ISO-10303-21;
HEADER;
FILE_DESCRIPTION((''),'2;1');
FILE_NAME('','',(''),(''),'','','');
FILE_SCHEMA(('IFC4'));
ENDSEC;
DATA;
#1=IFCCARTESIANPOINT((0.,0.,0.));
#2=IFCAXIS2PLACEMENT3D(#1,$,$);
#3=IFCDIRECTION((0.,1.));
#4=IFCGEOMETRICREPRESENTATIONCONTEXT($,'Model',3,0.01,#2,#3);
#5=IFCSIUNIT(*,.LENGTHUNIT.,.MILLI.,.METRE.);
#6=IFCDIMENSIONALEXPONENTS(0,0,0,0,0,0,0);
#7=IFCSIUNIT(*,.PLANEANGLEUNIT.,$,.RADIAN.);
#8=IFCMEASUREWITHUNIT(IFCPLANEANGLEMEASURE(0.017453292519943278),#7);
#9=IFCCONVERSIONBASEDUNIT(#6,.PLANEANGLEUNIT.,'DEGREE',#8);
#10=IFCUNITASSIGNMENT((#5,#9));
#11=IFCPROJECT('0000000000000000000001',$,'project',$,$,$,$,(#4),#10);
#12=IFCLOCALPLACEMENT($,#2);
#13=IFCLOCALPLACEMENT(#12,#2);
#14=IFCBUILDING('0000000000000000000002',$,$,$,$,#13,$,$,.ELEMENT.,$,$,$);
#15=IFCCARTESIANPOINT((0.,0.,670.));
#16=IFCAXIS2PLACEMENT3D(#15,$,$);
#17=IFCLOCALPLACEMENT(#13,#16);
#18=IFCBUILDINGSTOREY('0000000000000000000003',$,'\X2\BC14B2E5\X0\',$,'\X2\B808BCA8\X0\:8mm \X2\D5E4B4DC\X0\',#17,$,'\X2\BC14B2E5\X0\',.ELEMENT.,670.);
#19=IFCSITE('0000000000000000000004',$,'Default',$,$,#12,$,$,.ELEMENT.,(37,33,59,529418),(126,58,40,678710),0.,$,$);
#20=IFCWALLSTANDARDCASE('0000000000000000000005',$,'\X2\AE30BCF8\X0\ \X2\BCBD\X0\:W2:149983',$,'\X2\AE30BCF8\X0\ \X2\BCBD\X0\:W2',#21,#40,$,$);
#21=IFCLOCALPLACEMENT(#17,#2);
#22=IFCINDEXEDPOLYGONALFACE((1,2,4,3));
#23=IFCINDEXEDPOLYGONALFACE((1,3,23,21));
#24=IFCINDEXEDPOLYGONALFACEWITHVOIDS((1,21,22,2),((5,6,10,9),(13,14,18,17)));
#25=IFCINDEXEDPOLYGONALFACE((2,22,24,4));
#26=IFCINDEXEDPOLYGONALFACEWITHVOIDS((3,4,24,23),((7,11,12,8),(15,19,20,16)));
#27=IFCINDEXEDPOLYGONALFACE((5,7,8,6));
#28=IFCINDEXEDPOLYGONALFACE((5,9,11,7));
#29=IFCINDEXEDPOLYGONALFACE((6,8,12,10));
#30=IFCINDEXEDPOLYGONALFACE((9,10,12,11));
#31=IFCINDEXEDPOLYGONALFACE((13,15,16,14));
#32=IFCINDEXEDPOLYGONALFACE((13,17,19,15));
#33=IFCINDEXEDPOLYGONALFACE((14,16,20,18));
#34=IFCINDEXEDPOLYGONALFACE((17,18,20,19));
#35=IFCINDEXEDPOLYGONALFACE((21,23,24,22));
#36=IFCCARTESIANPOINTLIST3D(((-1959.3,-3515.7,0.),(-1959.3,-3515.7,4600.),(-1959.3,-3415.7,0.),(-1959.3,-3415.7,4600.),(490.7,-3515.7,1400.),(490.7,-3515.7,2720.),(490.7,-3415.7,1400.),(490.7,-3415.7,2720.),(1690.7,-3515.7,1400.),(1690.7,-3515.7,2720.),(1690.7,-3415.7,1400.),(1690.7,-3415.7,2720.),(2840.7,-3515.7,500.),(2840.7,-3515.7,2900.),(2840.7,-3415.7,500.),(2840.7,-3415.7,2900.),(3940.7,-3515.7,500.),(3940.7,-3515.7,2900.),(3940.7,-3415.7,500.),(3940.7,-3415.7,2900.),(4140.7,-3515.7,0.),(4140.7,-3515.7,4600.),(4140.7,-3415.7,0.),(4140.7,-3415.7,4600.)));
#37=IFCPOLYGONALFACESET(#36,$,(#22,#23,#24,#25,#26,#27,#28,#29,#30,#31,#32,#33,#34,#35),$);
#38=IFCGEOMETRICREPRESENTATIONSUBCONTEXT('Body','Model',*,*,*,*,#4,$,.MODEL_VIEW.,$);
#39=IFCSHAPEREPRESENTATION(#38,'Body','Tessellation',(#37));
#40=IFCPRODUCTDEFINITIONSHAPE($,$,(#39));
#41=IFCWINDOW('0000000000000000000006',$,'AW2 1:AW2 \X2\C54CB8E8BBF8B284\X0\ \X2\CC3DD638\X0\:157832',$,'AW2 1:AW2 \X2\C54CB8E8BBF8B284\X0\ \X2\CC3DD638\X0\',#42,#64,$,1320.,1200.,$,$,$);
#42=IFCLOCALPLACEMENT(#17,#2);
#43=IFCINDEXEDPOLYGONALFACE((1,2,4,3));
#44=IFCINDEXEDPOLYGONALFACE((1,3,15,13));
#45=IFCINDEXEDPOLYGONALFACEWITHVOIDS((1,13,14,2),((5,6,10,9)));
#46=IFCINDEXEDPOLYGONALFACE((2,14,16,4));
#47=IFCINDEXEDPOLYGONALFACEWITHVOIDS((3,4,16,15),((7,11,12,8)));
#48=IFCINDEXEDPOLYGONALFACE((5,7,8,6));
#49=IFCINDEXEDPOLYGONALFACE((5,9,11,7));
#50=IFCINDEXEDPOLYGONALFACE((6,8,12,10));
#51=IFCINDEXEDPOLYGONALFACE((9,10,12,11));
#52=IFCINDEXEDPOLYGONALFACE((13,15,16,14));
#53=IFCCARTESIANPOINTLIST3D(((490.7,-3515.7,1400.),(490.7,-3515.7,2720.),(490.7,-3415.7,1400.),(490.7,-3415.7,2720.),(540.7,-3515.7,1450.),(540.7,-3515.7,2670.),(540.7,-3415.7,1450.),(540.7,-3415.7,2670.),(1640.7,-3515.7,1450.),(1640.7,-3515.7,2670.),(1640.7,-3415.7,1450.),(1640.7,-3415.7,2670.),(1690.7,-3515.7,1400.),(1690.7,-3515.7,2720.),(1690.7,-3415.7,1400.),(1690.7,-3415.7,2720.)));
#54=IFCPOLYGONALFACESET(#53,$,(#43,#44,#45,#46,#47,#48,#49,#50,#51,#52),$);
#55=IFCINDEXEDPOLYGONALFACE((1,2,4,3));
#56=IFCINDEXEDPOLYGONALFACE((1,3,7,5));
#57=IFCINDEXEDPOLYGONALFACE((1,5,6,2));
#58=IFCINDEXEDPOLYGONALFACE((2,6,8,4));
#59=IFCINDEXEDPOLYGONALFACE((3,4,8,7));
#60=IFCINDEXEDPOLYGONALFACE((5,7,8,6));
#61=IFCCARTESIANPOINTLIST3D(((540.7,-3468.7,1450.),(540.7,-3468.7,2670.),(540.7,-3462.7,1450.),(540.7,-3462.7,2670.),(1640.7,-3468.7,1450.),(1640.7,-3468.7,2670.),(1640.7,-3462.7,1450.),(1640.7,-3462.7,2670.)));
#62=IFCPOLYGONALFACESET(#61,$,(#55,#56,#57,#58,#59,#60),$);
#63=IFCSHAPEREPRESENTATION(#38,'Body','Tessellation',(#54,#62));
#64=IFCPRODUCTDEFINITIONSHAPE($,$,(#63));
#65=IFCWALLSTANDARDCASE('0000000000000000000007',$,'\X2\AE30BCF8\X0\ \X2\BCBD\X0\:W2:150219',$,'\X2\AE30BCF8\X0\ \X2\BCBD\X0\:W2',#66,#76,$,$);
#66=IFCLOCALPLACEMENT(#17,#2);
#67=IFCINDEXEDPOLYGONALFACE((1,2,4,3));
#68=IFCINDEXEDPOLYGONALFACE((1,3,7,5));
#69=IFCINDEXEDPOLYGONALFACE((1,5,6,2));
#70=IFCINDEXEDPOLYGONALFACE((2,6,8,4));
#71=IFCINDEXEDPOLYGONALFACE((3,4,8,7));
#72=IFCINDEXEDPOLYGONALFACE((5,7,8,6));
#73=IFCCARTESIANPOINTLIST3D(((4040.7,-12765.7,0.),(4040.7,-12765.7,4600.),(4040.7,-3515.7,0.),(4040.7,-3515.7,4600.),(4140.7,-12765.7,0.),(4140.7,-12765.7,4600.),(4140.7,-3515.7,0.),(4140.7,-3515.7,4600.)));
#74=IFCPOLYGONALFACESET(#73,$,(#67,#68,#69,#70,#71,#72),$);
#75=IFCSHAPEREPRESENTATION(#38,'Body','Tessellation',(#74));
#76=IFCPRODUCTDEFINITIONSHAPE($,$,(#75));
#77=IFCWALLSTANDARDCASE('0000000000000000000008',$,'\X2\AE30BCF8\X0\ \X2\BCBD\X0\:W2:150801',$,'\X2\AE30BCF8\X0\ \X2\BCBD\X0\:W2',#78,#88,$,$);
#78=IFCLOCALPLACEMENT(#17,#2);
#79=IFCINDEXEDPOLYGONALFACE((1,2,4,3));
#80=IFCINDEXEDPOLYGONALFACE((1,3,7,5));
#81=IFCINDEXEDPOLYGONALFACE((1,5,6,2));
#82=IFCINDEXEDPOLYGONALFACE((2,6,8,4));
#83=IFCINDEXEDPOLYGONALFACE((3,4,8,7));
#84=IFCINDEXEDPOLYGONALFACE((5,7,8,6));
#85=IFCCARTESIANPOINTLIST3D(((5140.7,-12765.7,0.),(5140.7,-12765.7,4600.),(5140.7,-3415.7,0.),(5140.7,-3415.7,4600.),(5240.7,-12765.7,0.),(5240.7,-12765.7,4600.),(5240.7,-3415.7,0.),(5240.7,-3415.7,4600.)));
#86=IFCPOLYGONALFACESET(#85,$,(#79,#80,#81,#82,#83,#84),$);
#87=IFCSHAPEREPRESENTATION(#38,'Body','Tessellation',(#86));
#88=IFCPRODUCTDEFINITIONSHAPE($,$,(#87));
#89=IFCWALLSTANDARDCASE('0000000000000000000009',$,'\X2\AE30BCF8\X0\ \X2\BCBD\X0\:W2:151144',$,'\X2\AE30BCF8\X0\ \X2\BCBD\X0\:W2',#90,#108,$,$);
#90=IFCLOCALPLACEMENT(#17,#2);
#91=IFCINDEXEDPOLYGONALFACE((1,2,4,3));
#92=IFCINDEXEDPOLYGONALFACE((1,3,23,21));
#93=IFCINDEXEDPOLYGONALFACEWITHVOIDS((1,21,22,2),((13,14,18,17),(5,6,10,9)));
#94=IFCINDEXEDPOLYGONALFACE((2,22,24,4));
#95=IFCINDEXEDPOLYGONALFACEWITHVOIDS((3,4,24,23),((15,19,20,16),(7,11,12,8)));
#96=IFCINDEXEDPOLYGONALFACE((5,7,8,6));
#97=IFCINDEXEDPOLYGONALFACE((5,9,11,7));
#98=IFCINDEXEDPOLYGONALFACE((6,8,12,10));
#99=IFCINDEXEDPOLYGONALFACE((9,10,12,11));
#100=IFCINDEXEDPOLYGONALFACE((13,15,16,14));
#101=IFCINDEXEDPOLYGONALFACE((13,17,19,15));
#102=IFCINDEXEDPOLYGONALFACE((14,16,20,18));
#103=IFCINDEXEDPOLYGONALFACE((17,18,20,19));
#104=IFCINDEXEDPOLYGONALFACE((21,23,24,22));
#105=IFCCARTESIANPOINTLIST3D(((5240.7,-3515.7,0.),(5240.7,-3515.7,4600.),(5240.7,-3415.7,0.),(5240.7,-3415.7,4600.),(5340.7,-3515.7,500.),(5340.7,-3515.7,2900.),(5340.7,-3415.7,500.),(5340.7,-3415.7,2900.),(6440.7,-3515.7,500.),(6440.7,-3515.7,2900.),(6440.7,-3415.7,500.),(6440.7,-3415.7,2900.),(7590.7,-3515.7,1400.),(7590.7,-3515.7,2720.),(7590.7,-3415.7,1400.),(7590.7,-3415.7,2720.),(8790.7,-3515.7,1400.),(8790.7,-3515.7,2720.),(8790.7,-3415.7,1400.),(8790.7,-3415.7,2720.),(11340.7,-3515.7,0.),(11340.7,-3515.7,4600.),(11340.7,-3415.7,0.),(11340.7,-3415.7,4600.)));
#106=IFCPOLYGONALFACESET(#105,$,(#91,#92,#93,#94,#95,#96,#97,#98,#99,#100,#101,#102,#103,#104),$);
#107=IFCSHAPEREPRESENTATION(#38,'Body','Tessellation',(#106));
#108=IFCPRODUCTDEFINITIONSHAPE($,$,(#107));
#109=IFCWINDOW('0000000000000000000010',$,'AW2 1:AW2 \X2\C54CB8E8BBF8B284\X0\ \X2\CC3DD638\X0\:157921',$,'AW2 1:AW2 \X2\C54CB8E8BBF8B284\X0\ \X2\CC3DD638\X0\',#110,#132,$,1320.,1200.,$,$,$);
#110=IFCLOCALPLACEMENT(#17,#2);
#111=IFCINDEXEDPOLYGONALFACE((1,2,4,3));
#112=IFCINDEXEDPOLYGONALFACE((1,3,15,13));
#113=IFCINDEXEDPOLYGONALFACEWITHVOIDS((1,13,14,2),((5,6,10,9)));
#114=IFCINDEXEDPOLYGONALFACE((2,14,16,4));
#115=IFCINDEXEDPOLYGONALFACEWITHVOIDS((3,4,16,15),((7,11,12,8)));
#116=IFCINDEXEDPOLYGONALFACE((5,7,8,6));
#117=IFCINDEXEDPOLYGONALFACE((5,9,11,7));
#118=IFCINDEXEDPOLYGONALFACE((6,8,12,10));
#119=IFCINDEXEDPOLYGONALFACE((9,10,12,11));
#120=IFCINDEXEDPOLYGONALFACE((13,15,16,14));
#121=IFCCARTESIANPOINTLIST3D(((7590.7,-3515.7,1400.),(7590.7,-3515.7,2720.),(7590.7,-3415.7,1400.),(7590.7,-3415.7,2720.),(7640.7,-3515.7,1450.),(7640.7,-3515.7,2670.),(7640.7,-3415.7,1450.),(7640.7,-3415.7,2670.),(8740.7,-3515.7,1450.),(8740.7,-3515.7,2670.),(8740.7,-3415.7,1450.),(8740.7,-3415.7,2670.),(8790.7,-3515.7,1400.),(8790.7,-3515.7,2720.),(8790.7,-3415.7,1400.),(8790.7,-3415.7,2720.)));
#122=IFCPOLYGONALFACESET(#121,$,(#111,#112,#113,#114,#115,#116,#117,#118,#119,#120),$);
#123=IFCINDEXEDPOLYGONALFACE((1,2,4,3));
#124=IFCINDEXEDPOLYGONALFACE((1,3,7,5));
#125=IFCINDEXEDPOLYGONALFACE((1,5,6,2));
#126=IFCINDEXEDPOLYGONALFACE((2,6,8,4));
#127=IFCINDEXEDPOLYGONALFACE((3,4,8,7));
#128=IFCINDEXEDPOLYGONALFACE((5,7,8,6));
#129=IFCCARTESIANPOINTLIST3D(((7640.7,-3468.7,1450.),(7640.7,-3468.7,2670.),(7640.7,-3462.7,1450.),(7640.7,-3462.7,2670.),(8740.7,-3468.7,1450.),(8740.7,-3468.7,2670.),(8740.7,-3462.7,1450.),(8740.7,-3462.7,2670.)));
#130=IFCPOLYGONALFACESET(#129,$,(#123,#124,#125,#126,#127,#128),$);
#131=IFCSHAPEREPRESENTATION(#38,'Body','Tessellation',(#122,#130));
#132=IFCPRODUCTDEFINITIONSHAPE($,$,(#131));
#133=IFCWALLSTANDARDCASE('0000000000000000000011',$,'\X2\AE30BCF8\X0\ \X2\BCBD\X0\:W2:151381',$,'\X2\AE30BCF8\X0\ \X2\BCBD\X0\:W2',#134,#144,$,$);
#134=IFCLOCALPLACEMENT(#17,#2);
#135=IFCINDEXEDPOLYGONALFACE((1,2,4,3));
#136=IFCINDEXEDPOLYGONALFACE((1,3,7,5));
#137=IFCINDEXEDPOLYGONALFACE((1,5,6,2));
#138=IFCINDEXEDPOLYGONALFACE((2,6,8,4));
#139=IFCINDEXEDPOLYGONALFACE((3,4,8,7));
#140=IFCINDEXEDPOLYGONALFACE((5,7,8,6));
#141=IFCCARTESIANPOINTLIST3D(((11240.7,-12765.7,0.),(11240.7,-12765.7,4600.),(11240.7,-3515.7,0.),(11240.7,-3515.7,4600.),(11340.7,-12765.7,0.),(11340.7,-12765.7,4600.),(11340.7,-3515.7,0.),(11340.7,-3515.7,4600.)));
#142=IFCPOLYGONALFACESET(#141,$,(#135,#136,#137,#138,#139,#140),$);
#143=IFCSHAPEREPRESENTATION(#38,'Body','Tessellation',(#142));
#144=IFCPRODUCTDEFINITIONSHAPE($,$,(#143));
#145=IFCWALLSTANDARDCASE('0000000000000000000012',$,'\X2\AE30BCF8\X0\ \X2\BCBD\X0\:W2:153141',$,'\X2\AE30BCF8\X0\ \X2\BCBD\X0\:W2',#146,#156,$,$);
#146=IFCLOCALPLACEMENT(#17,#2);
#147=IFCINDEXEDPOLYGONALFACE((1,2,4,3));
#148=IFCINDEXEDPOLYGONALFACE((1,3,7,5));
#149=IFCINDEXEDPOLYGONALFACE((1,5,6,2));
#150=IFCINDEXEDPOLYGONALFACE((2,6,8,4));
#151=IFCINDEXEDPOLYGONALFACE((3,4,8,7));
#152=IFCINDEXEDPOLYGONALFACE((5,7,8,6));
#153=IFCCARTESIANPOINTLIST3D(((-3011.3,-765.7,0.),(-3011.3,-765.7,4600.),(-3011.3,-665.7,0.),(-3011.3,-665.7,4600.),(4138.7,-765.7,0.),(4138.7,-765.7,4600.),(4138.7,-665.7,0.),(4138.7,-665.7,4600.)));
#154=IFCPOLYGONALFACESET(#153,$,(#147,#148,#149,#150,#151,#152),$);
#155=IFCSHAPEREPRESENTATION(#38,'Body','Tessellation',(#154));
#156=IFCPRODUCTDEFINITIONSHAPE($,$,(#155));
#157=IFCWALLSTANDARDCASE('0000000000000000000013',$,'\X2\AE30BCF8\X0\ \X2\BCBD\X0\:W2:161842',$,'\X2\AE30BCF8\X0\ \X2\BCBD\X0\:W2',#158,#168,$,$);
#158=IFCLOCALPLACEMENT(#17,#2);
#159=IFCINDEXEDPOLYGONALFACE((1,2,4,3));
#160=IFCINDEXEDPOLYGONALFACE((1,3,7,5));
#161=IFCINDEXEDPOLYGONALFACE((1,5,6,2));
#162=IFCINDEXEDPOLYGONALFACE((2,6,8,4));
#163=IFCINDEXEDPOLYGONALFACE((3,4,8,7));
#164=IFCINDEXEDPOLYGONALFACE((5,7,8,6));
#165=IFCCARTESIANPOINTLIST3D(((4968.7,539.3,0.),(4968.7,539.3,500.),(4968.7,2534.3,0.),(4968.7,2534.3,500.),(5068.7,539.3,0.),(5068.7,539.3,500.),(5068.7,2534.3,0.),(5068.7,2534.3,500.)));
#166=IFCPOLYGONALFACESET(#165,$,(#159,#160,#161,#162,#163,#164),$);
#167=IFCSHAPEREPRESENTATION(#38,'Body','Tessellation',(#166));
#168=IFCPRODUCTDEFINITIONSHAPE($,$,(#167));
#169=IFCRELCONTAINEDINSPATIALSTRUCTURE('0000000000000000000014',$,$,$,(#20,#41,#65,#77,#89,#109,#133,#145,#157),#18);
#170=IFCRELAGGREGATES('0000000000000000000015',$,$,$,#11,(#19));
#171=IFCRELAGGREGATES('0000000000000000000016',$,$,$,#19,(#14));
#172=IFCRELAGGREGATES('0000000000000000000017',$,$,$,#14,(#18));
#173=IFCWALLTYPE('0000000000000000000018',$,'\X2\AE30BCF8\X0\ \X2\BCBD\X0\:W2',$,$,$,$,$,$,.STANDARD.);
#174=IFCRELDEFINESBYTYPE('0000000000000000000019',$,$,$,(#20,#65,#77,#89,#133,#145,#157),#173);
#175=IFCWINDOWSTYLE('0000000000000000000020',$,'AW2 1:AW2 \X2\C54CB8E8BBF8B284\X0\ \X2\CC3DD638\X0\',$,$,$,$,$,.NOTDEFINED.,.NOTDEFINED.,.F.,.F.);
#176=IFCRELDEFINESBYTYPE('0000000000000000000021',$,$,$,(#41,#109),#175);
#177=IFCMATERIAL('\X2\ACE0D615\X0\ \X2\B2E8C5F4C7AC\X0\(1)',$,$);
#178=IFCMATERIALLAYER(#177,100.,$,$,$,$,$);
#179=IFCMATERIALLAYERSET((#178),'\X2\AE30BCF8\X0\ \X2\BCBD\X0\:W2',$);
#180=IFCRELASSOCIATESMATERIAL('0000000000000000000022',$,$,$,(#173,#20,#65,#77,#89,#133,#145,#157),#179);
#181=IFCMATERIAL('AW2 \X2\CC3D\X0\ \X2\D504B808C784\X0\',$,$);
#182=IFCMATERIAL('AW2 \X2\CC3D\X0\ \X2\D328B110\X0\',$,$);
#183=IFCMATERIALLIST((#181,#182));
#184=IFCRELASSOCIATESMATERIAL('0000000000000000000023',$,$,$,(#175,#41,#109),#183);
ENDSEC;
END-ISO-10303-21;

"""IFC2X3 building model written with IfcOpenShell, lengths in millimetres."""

from ifc_helpers import new_model, entity, si_unit, converted_unit, direction, frame, frame_2d, origin, origin_2d_with_axis, place, context, subcontext, project, spatial, polyline, rectangle, outline, extrude, source, transform, mapped, material, material_list, layer, layer_set, layer_usage, type_object, type_shapes, element, fill, save


model = new_model("IFC2X3")

# Units and contexts
model_context = context("Model", 3, precision=0.01, world=origin(), true_north=direction((0.0, 1.0)))
body_context = subcontext(model_context, "Body", "Model", "MODEL_VIEW")
ifc_project = project(units=[si_unit("LENGTHUNIT", "METRE", prefix="MILLI"), converted_unit("PLANEANGLEUNIT", "DEGREE", entity("IfcPlaneAngleMeasure", 0.017453292519943278), si_unit("PLANEANGLEUNIT", "RADIAN"), dimensions=[0, 0, 0, 0, 0, 0, 0])], contexts=[model_context])

# Site, building, storey
site_placement = place(None, origin())
site = spatial("IfcSite", under=ifc_project, at=site_placement, Name="Default", CompositionType="ELEMENT", RefLatitude=(37, 33, 59, 529418), RefLongitude=(126, 58, 40, 678710), RefElevation=0.0)
building_placement = place(site_placement, origin())
building = spatial("IfcBuilding", under=site, at=building_placement, CompositionType="ELEMENT")
storey_placement = place(building_placement, frame((0.0, 0.0, 670.0)))
storey = spatial("IfcBuildingStorey", under=building, at=storey_placement, Name="바닥", ObjectType="레벨:8mm 헤드", LongName="바닥", CompositionType="ELEMENT", Elevation=670.0)

# Shared definitions
ifc_material_1 = material(Name="고형 단열재(1)")
ifc_layer_1 = layer(ifc_material_1, 100.0)
ifc_layer_set_1 = layer_set([ifc_layer_1], Name="기본 벽:W2")
wall_type_1 = type_object("IfcWallType", Name="기본 벽:W2", PredefinedType="STANDARD", material=ifc_layer_set_1)

# Wall, openings, window
ifc_layer_usage_1 = layer_usage(ifc_layer_set_1, "AXIS2", "NEGATIVE", 50.0)
wall_1_placement = place(storey_placement, frame((-1959.3, -3465.7, 0.0)))
wall_1 = element("IfcWallStandardCase", 1, at=wall_1_placement, inside=storey, type_object=wall_type_1, material=ifc_layer_usage_1, Name="기본 벽:W2:149983", ObjectType="기본 벽:W2", context=body_context, shape_type="SweptSolid", body=[
    extrude(rectangle(XDim=6100.0, YDim=100.0, at=frame_2d((3050.0, 0.0), x_axis=(-1.0, 0.0))), origin(), (0.0, 0.0, 1.0), 4600.0),
])
opening_1_placement = place(wall_1_placement, frame((4800.0, -50.0, 500.0)))
element("IfcOpeningElement", 2, at=opening_1_placement, cuts=wall_1, ObjectType="Opening", context=body_context, shape_type="SweptSolid", body=[
    extrude(rectangle(XDim=2400.0, YDim=1100.0, at=frame_2d((1200.0, 550.0), x_axis=(1.0, 0.0))), frame((0.0, 0.0, 0.0), z_axis=(0.0, 1.0, 0.0), x_axis=(0.0, 0.0, 1.0)), (0.0, 0.0, 1.0), 100.0),
])
opening_2_placement = place(wall_1_placement, frame((2450.0, -50.0, 1400.0)))
opening_2 = element("IfcOpeningElement", 3, at=opening_2_placement, cuts=wall_1, ObjectType="Opening", context=body_context, shape_type="SweptSolid", body=[
    extrude(rectangle(XDim=1320.0, YDim=1200.0, at=frame_2d((660.0, 600.0), x_axis=(1.0, 0.0))), frame((0.0, 0.0, 0.0), z_axis=(0.0, 1.0, 0.0), x_axis=(0.0, 0.0, 1.0)), (0.0, 0.0, 1.0), 100.0),
])
ifc_material_2 = material(Name="AW2 창 프레임")
ifc_material_3 = material(Name="AW2 창 패널")
ifc_material_list = material_list([ifc_material_2, ifc_material_3])
window_style = type_object("IfcWindowStyle", Name="AW2 1:AW2 알루미늄 창호", ConstructionType="NOTDEFINED", OperationType="NOTDEFINED", ParameterTakesPrecedence=False, Sizeable=False, material=ifc_material_list)
shared_shape = source(origin(), body_context, "Body", "SweptSolid", [
    extrude(outline(polyline([(-600.0, -660.0), (600.0, -660.0), (600.0, 660.0), (-600.0, 660.0), (-600.0, -660.0)]), holes=[polyline([(-550.0, -610.0), (-550.0, 610.0), (550.0, 610.0), (550.0, -610.0), (-550.0, -610.0)])]), frame((600.0, 0.0, 660.0), z_axis=(0.0, 1.0, 0.0), x_axis=(1.0, 0.0, 0.0)), (0.0, 0.0, 1.0), 100.0),
    extrude(rectangle(XDim=6.0, YDim=1100.0, at=origin_2d_with_axis()), frame((600.0, 50.0, 50.0), z_axis=(0.0, 0.0, 1.0), x_axis=(0.0, -1.0, 0.0)), (0.0, 0.0, 1.0), 1220.0),
])
type_shapes(window_style, [shared_shape])
window_1_placement = place(opening_2_placement, origin())
window_1 = element("IfcWindow", 4, at=window_1_placement, inside=storey, type_object=window_style, material=ifc_material_list, Name="AW2 1:AW2 알루미늄 창호:157832", ObjectType="AW2 1:AW2 알루미늄 창호", OverallHeight=1320.0, OverallWidth=1200.0, context=body_context, shape_type="MappedRepresentation", body=[
    mapped(shared_shape, transform((0.0, 0.0, 0.0), scale=1.0)),
])
fill(opening_2, window_1)

# Walls
ifc_layer_usage_2 = layer_usage(ifc_layer_set_1, "AXIS2", "NEGATIVE", 50.0)
wall_2_placement = place(storey_placement, frame((4090.7, -3515.7, 0.0), z_axis=(0.0, 0.0, 1.0), x_axis=(0.0, -1.0, 0.0)))
element("IfcWallStandardCase", 5, at=wall_2_placement, inside=storey, type_object=wall_type_1, material=ifc_layer_usage_2, Name="기본 벽:W2:150219", ObjectType="기본 벽:W2", context=body_context, shape_type="SweptSolid", body=[
    extrude(rectangle(XDim=9250.0, YDim=100.0, at=frame_2d((4625.0, 0.0), x_axis=(-1.0, 0.0))), origin(), (0.0, 0.0, 1.0), 4600.0),
])
ifc_layer_usage_3 = layer_usage(ifc_layer_set_1, "AXIS2", "NEGATIVE", 50.0)
wall_3_placement = place(storey_placement, frame((5190.7, -12765.7, 0.0), z_axis=(0.0, 0.0, 1.0), x_axis=(0.0, 1.0, 0.0)))
element("IfcWallStandardCase", 6, at=wall_3_placement, inside=storey, type_object=wall_type_1, material=ifc_layer_usage_3, Name="기본 벽:W2:150801", ObjectType="기본 벽:W2", context=body_context, shape_type="SweptSolid", body=[
    extrude(rectangle(XDim=9350.0, YDim=100.0, at=frame_2d((4675.0, 0.0), x_axis=(-1.0, 0.0))), origin(), (0.0, 0.0, 1.0), 4600.0),
])

# Wall, openings, window
ifc_layer_usage_4 = layer_usage(ifc_layer_set_1, "AXIS2", "NEGATIVE", 50.0)
wall_4_placement = place(storey_placement, frame((5240.7, -3465.7, 0.0)))
wall_4 = element("IfcWallStandardCase", 7, at=wall_4_placement, inside=storey, type_object=wall_type_1, material=ifc_layer_usage_4, Name="기본 벽:W2:151144", ObjectType="기본 벽:W2", context=body_context, shape_type="SweptSolid", body=[
    extrude(rectangle(XDim=6100.0, YDim=100.0, at=frame_2d((3050.0, 0.0), x_axis=(-1.0, 0.0))), origin(), (0.0, 0.0, 1.0), 4600.0),
])
opening_3_placement = place(wall_4_placement, frame((100.0, -50.0, 500.0)))
element("IfcOpeningElement", 8, at=opening_3_placement, cuts=wall_4, ObjectType="Opening", context=body_context, shape_type="SweptSolid", body=[
    extrude(rectangle(XDim=2400.0, YDim=1100.0, at=frame_2d((1200.0, 550.0), x_axis=(1.0, 0.0))), frame((0.0, 0.0, 0.0), z_axis=(0.0, 1.0, 0.0), x_axis=(0.0, 0.0, 1.0)), (0.0, 0.0, 1.0), 100.0),
])
opening_4_placement = place(wall_4_placement, frame((3550.0, 50.0, 1400.0)))
opening_4 = element("IfcOpeningElement", 9, at=opening_4_placement, cuts=wall_4, ObjectType="Opening", context=body_context, shape_type="SweptSolid", body=[
    extrude(rectangle(XDim=1320.0, YDim=1200.0, at=frame_2d((660.0, 600.0), x_axis=(1.0, 0.0))), frame((0.0, 0.0, 0.0), z_axis=(0.0, -1.0, 0.0), x_axis=(0.0, 0.0, 1.0)), (0.0, 0.0, 1.0), 100.0),
])
window_2_placement = place(opening_4_placement, frame((0.0, 0.0, 0.0), z_axis=(0.0, 0.0, 1.0), x_axis=(-1.0, 0.0, 0.0)))
window_2 = element("IfcWindow", 10, at=window_2_placement, inside=storey, type_object=window_style, material=ifc_material_list, Name="AW2 1:AW2 알루미늄 창호:157921", ObjectType="AW2 1:AW2 알루미늄 창호", OverallHeight=1320.0, OverallWidth=1200.0, context=body_context, shape_type="MappedRepresentation", body=[
    mapped(shared_shape, transform((0.0, 0.0, 0.0), scale=1.0)),
])
fill(opening_4, window_2)

# Walls
ifc_layer_usage_5 = layer_usage(ifc_layer_set_1, "AXIS2", "NEGATIVE", 50.0)
wall_5_placement = place(storey_placement, frame((11290.7, -3515.7, 0.0), z_axis=(0.0, 0.0, 1.0), x_axis=(0.0, -1.0, 0.0)))
element("IfcWallStandardCase", 11, at=wall_5_placement, inside=storey, type_object=wall_type_1, material=ifc_layer_usage_5, Name="기본 벽:W2:151381", ObjectType="기본 벽:W2", context=body_context, shape_type="SweptSolid", body=[
    extrude(rectangle(XDim=9250.0, YDim=100.0, at=frame_2d((4625.0, 0.0), x_axis=(-1.0, 0.0))), origin(), (0.0, 0.0, 1.0), 4600.0),
])
ifc_layer_usage_6 = layer_usage(ifc_layer_set_1, "AXIS2", "NEGATIVE", 50.0)
wall_6_placement = place(storey_placement, frame((4138.7, -715.7, 0.0), z_axis=(0.0, 0.0, 1.0), x_axis=(-1.0, 0.0, 0.0)))
element("IfcWallStandardCase", 12, at=wall_6_placement, inside=storey, type_object=wall_type_1, material=ifc_layer_usage_6, Name="기본 벽:W2:153141", ObjectType="기본 벽:W2", context=body_context, shape_type="SweptSolid", body=[
    extrude(rectangle(XDim=7150.0, YDim=100.0, at=frame_2d((3575.0, 0.0), x_axis=(-1.0, 0.0))), origin(), (0.0, 0.0, 1.0), 4600.0),
])
ifc_layer_usage_7 = layer_usage(ifc_layer_set_1, "AXIS2", "NEGATIVE", 50.0)
wall_7_placement = place(storey_placement, frame((5018.7, 2534.3, 0.0), z_axis=(0.0, 0.0, 1.0), x_axis=(0.0, -1.0, 0.0)))
element("IfcWallStandardCase", 13, at=wall_7_placement, inside=storey, type_object=wall_type_1, material=ifc_layer_usage_7, Name="기본 벽:W2:161842", ObjectType="기본 벽:W2", context=body_context, shape_type="SweptSolid", body=[
    extrude(rectangle(XDim=1995.0, YDim=100.0, at=frame_2d((997.5, 0.0), x_axis=(-1.0, 0.0))), origin(), (0.0, 0.0, 1.0), 500.0),
])

save(model, "model.ifc")
